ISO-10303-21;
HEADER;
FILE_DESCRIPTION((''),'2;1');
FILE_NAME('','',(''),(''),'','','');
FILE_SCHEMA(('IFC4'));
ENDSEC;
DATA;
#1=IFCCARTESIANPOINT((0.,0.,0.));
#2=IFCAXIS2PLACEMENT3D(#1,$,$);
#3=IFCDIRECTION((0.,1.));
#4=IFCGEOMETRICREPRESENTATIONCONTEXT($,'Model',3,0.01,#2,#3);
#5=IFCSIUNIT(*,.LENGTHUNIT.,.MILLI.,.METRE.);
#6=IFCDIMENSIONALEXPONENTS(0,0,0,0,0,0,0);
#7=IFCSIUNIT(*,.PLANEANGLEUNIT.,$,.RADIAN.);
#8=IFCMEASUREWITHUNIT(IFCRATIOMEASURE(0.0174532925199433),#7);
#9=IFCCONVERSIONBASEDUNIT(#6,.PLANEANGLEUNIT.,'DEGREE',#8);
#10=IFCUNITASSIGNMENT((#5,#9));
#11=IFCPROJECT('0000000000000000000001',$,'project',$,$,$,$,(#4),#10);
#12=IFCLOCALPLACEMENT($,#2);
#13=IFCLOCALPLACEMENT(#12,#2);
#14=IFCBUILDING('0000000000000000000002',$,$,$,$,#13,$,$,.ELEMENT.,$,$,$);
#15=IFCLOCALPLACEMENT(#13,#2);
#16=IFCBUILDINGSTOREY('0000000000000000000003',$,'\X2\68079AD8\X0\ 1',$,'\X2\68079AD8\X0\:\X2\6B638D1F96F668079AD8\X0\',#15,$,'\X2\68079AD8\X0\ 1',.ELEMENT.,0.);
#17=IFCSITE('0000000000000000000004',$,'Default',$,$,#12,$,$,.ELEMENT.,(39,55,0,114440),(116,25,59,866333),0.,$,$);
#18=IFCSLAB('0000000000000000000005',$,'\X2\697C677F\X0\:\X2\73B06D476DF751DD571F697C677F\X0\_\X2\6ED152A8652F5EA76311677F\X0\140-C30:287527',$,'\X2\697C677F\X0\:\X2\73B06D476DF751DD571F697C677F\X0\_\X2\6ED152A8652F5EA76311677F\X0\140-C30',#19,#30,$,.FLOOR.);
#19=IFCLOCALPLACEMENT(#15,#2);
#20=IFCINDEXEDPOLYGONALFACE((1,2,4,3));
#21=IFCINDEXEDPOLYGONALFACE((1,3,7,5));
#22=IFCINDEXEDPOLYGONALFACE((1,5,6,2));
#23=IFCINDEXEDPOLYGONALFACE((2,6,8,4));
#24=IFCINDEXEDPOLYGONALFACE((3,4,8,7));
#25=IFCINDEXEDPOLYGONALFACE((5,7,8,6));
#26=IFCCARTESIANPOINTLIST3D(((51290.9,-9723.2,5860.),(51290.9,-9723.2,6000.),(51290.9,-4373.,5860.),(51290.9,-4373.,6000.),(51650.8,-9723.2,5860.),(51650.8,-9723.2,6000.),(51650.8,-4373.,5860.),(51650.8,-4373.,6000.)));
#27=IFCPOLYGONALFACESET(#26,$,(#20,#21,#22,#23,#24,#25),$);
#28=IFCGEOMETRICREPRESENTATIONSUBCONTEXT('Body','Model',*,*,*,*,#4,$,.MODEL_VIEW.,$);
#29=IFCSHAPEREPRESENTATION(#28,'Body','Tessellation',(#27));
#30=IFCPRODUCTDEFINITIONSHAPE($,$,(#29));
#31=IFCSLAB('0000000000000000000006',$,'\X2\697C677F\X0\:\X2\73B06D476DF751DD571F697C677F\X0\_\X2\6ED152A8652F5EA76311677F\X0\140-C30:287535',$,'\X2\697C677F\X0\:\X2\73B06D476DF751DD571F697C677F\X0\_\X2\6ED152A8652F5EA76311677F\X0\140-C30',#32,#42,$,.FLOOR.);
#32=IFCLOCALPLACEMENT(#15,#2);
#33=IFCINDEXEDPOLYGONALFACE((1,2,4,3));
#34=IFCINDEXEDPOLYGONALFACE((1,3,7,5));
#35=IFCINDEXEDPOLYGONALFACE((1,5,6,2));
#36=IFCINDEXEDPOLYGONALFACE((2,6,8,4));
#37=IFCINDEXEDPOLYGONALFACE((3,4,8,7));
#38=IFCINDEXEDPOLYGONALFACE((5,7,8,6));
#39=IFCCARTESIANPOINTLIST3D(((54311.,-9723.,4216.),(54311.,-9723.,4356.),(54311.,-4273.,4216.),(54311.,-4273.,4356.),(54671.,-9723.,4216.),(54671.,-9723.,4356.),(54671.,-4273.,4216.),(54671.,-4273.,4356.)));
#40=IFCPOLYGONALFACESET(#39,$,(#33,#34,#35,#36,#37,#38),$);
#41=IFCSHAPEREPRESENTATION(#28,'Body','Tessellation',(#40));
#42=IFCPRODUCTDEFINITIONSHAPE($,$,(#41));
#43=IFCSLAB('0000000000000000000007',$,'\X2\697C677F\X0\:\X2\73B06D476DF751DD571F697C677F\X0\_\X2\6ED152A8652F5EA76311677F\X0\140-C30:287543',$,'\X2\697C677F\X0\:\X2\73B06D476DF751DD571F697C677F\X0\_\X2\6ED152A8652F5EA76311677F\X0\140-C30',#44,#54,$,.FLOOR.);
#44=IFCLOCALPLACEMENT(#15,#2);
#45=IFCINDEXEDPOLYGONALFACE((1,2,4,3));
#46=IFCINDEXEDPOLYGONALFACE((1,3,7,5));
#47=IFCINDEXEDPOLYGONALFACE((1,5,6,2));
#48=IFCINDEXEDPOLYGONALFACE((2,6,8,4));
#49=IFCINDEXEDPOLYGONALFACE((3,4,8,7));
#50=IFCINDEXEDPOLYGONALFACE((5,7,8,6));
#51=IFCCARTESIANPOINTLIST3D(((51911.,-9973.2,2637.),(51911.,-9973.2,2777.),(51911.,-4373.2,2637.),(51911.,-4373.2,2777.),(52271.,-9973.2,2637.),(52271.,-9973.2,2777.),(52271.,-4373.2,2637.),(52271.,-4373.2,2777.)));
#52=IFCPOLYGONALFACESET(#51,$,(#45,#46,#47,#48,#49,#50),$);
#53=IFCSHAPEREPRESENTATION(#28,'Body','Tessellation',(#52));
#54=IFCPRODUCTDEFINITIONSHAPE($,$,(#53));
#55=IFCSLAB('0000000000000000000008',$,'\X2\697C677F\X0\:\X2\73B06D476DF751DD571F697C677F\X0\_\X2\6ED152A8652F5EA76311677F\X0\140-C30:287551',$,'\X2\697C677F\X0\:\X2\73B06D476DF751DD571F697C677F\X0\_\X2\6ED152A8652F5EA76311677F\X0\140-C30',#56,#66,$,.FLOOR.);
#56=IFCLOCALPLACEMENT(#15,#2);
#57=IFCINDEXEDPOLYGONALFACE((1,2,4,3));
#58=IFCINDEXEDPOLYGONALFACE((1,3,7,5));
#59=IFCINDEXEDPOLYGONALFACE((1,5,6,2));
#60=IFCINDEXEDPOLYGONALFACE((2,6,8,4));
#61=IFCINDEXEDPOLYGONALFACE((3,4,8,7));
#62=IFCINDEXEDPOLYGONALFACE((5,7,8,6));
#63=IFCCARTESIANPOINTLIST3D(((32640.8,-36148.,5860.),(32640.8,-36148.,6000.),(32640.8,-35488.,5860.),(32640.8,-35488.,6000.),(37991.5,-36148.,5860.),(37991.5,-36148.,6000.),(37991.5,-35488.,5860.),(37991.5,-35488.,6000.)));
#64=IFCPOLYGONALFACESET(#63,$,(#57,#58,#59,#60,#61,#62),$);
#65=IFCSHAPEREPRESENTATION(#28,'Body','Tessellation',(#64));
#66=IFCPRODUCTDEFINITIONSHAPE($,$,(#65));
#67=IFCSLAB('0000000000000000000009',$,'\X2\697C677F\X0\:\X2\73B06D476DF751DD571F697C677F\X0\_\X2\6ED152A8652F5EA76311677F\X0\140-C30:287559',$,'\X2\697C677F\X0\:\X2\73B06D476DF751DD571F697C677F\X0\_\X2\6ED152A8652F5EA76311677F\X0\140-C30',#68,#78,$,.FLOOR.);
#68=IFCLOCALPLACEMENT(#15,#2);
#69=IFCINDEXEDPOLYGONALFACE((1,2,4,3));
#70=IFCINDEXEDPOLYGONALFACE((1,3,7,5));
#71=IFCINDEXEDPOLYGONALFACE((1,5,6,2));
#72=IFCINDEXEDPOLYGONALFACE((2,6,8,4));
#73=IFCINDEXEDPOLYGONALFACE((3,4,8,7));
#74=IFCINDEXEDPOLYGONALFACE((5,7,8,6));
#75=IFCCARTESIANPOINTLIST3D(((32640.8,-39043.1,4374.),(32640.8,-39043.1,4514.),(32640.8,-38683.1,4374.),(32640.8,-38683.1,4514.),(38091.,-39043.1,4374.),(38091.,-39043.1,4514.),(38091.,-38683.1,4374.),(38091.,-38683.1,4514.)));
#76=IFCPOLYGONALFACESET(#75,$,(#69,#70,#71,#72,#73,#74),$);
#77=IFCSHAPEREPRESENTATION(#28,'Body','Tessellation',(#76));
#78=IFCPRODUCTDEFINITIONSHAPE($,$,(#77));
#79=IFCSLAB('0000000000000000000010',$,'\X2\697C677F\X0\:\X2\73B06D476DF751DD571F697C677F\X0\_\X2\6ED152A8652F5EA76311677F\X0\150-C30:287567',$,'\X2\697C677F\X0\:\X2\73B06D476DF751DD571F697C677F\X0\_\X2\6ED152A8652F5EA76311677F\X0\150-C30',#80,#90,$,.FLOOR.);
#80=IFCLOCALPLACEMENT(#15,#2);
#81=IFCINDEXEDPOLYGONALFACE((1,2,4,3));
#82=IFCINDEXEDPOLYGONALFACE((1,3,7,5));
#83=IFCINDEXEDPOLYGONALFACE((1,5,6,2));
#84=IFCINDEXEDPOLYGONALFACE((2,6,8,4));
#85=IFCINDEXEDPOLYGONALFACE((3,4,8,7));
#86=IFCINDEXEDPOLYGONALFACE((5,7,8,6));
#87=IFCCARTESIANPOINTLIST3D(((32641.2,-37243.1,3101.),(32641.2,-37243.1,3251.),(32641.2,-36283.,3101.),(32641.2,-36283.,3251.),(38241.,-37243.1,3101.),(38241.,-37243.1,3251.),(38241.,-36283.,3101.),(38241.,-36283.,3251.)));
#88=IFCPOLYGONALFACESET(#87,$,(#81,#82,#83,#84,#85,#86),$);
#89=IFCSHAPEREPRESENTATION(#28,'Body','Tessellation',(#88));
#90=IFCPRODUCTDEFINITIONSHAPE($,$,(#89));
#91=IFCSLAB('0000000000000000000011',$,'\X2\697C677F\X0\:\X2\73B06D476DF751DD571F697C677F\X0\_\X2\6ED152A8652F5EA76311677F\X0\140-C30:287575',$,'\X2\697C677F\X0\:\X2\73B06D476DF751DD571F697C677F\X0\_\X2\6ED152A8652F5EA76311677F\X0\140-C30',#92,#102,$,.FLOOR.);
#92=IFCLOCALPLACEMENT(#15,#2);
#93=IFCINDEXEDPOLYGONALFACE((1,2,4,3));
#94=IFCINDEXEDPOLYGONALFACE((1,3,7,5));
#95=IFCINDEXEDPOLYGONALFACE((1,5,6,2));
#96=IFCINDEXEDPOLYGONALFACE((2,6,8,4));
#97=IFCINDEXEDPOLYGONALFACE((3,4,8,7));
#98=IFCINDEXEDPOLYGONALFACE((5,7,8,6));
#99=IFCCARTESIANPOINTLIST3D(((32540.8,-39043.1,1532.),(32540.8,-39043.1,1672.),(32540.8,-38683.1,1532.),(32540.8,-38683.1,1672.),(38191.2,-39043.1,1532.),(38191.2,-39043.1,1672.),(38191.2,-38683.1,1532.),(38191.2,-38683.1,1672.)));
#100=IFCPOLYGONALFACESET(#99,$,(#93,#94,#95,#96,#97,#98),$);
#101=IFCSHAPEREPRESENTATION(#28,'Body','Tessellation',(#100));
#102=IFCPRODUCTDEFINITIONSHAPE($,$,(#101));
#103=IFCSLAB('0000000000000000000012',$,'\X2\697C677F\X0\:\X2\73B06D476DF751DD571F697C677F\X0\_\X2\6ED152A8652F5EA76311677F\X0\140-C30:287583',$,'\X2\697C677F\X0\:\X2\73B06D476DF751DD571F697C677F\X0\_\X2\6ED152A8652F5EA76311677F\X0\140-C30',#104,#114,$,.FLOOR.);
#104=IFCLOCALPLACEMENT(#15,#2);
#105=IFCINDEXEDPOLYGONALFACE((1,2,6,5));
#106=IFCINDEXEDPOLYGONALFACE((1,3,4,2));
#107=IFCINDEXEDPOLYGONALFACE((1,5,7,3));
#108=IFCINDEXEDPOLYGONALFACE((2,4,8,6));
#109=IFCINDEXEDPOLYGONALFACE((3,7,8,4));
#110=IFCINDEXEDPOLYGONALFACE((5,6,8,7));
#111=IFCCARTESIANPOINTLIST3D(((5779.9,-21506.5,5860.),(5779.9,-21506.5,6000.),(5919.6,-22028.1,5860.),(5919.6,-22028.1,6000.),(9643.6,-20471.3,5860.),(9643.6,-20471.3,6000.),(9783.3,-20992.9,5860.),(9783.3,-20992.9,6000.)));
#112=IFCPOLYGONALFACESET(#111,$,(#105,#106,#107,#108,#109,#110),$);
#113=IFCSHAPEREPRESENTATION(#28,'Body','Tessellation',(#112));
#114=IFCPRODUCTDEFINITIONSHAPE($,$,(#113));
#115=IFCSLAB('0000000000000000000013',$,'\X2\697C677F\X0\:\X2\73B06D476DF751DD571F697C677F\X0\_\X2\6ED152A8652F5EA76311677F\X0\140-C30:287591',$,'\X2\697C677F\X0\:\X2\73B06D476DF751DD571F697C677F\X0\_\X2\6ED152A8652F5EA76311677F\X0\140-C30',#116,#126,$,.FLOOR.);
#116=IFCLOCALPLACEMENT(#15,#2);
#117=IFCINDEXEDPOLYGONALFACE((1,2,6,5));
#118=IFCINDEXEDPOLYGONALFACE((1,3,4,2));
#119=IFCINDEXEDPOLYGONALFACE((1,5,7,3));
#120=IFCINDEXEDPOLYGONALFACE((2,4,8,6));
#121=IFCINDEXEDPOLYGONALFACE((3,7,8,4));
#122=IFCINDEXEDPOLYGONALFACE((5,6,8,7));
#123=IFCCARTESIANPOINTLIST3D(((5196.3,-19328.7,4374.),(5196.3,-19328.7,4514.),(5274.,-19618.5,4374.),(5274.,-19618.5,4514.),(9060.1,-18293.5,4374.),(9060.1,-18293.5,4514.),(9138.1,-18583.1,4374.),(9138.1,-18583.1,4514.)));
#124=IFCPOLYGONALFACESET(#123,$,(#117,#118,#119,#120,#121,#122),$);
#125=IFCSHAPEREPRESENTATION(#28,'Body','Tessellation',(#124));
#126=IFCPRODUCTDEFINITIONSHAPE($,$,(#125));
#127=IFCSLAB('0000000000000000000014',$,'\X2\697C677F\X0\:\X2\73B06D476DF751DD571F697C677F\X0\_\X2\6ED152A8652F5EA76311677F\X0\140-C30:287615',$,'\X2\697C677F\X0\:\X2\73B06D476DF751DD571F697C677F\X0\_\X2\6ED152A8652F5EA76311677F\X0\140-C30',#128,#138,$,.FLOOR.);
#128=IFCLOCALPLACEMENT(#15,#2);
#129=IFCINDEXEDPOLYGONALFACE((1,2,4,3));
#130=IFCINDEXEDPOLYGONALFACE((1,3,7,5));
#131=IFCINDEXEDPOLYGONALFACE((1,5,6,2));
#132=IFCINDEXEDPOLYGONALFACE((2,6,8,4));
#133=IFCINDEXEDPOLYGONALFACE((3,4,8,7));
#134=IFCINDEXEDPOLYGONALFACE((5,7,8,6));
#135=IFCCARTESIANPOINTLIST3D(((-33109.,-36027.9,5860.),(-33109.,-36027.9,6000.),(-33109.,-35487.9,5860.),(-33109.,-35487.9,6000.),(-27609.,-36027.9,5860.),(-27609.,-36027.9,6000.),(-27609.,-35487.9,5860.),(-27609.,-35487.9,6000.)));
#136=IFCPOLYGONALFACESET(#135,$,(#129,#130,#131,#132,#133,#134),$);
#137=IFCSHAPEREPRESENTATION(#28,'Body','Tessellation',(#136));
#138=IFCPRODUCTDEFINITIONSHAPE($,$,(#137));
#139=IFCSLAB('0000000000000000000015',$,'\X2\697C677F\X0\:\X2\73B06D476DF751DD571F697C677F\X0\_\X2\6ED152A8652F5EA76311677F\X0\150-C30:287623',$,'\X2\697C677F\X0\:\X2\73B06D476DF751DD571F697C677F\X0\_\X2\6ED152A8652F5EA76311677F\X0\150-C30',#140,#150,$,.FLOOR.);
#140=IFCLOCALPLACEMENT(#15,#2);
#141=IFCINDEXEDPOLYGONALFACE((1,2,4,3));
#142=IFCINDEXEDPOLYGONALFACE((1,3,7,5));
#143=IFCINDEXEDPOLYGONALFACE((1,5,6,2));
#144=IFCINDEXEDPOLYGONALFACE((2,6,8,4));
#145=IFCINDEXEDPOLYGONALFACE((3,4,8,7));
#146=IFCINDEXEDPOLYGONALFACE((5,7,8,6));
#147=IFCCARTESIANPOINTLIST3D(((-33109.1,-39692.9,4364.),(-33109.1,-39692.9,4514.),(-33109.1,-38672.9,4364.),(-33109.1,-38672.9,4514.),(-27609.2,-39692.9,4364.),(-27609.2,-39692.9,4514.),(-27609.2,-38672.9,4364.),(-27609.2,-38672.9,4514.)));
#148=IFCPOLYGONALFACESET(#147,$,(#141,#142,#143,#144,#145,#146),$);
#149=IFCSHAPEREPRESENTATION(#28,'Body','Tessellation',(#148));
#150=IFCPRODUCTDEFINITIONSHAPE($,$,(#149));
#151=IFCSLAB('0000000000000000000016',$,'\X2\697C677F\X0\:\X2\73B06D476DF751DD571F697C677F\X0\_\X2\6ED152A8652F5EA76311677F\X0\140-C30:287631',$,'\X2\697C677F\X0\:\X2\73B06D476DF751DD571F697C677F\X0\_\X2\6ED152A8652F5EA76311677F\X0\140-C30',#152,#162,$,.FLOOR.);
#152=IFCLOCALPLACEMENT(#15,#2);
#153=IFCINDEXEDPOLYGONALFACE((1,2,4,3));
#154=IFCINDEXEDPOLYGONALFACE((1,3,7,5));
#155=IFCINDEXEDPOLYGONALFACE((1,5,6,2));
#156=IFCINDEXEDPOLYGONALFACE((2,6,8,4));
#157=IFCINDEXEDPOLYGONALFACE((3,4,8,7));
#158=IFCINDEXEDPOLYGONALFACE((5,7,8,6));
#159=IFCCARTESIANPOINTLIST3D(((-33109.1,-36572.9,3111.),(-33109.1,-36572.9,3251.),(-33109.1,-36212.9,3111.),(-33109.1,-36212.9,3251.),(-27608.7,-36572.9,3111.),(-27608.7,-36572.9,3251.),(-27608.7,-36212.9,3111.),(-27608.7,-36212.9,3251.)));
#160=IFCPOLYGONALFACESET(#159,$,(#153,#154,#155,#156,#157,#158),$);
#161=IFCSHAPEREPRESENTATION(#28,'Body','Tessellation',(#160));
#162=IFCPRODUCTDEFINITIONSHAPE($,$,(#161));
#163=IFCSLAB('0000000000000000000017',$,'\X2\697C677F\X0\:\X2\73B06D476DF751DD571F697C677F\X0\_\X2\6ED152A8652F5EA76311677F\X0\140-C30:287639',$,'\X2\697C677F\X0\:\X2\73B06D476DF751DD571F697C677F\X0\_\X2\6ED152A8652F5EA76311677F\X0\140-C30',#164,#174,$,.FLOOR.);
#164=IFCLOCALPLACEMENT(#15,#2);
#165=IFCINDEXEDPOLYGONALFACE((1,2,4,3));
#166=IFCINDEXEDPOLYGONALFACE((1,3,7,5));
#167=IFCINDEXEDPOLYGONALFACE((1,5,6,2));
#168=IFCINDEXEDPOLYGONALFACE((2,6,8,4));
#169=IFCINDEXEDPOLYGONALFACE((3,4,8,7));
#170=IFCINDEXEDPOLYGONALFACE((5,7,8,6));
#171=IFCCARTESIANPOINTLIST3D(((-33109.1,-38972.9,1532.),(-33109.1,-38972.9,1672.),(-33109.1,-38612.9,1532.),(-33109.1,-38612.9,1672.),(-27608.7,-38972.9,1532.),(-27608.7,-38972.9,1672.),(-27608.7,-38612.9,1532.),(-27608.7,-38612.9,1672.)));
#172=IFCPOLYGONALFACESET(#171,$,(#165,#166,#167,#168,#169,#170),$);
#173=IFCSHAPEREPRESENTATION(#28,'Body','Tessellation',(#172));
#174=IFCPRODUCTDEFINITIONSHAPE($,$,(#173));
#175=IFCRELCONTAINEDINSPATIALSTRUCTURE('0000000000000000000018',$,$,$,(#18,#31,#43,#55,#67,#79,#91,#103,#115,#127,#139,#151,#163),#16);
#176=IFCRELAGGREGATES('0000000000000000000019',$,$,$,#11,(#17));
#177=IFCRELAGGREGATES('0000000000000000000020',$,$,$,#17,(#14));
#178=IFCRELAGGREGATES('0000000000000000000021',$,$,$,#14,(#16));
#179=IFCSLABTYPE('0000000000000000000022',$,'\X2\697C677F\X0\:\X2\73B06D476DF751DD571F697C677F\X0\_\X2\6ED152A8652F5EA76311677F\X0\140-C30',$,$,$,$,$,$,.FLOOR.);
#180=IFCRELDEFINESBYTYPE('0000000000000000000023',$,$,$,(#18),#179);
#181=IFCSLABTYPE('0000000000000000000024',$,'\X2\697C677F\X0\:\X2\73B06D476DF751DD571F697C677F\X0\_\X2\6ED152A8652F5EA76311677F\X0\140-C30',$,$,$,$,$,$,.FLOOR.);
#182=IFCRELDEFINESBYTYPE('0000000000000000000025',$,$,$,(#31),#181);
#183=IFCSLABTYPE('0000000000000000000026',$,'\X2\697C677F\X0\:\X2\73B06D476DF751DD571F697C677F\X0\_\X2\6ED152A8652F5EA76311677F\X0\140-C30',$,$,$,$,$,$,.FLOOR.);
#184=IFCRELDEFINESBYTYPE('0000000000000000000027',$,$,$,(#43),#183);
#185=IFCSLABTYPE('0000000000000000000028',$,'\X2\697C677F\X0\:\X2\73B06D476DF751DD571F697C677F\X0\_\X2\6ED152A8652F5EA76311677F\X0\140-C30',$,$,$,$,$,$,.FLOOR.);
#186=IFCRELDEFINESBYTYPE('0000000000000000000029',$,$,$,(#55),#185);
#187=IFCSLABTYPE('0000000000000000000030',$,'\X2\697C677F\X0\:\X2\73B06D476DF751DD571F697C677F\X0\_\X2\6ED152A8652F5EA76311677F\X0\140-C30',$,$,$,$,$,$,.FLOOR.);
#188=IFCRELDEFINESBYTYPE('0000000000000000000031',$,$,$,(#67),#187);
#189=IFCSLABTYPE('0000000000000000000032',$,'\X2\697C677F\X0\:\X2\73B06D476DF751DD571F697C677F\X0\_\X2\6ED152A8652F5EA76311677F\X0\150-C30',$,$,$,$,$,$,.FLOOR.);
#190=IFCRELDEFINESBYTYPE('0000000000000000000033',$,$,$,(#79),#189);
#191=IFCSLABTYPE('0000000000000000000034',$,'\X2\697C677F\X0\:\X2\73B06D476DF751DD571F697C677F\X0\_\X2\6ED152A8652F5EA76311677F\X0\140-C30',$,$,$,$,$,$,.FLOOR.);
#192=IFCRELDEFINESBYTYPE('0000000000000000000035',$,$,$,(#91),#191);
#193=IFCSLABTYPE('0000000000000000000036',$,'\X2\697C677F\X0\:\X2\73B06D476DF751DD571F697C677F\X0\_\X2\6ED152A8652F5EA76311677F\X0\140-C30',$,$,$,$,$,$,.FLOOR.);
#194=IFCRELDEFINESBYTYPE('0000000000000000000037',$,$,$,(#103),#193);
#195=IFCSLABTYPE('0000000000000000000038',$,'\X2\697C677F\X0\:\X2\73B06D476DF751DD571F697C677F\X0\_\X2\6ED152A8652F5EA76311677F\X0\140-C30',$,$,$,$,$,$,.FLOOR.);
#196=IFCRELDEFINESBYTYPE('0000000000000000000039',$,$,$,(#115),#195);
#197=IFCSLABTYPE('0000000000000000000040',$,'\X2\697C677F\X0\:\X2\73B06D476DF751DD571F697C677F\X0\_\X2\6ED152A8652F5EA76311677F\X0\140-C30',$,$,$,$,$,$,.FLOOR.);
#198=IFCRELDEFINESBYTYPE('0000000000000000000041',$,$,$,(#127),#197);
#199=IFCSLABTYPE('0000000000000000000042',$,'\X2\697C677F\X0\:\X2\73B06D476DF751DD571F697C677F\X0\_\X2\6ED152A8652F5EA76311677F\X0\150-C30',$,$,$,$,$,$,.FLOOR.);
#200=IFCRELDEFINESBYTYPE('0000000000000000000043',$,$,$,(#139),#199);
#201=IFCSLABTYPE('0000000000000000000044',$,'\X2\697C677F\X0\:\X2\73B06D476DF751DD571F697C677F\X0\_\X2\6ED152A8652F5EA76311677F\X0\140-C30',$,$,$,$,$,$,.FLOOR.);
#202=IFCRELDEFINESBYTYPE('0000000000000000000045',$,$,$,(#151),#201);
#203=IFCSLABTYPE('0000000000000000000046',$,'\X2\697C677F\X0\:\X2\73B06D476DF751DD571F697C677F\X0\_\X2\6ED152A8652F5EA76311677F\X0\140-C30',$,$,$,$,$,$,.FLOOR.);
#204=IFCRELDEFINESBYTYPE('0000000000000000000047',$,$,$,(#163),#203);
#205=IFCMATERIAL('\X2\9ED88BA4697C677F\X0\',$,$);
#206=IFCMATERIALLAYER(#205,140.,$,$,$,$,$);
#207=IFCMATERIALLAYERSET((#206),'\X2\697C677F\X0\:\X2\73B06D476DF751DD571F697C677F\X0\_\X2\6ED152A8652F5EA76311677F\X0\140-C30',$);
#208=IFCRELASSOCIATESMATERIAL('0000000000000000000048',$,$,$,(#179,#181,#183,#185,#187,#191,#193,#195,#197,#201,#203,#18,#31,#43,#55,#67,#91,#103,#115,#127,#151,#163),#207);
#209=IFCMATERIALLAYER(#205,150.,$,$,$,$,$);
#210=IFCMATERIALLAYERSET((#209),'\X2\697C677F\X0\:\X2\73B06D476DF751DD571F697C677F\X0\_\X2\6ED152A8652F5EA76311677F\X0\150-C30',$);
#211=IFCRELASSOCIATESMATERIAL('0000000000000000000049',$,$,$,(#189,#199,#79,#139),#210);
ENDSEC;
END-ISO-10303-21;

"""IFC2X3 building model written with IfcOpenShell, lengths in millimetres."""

from ifc_helpers import new_model, entity, si_unit, converted_unit, direction, frame, frame_2d, origin, origin_2d_with_axis, place, context, subcontext, project, spatial, polyline, rectangle, outline, extrude, material, layer, layer_set, layer_usage, type_object, element, save


model = new_model("IFC2X3")

# Units and contexts
model_context = context("Model", 3, precision=0.01, world=origin(), true_north=direction((0.0, 1.0)))
body_context = subcontext(model_context, "Body", "Model", "MODEL_VIEW")
ifc_project = project(units=[si_unit("LENGTHUNIT", "METRE", prefix="MILLI"), converted_unit("PLANEANGLEUNIT", "DEGREE", entity("IfcRatioMeasure", 0.0174532925199433), si_unit("PLANEANGLEUNIT", "RADIAN"), dimensions=[0, 0, 0, 0, 0, 0, 0])], contexts=[model_context])

# Site, building, storey
site_placement = place(None, origin())
site = spatial("IfcSite", under=ifc_project, at=site_placement, Name="Default", CompositionType="ELEMENT", RefLatitude=(39, 55, 0, 114440), RefLongitude=(116, 25, 59, 866333), RefElevation=0.0)
building_placement = place(site_placement, origin())
building = spatial("IfcBuilding", under=site, at=building_placement, CompositionType="ELEMENT")
storey_placement = place(building_placement, origin())
storey = spatial("IfcBuildingStorey", under=building, at=storey_placement, Name="标高 1", ObjectType="标高:正负零标高", LongName="标高 1", CompositionType="ELEMENT", Elevation=0.0)

# Slabs
ifc_material = material(Name="默认楼板")
ifc_layer_1 = layer(ifc_material, 140.0)
ifc_layer_set_1 = layer_set([ifc_layer_1], Name="楼板:现浇混凝土楼板_滑动支座挑板140-C30")
ifc_layer_2 = layer(ifc_material, 150.0)
ifc_layer_set_2 = layer_set([ifc_layer_2], Name="楼板:现浇混凝土楼板_滑动支座挑板150-C30")
ifc_layer_usage_1 = layer_usage(ifc_layer_set_1, "AXIS3", "POSITIVE", 0.0)
slab_type_1 = type_object("IfcSlabType", Name="楼板:现浇混凝土楼板_滑动支座挑板140-C30", PredefinedType="FLOOR", material=ifc_layer_set_1)
slab_1_placement = place(building_placement, origin())
element("IfcSlab", 1, at=slab_1_placement, inside=storey, type_object=slab_type_1, material=ifc_layer_usage_1, Name="楼板:现浇混凝土楼板_滑动支座挑板140-C30:287527", ObjectType="楼板:现浇混凝土楼板_滑动支座挑板140-C30", PredefinedType="FLOOR", context=body_context, shape_type="SweptSolid", body=[
    extrude(rectangle(XDim=5350.2, YDim=360.0, at=frame_2d((0.0, 0.0), x_axis=(1.0, 0.0))), frame((51470.8, -7048.1, 6000.0), z_axis=(0.0, 0.0, -1.0), x_axis=(0.0, 1.0, 0.0)), (0.0, 0.0, 1.0), 140.0),
])
ifc_layer_usage_2 = layer_usage(ifc_layer_set_1, "AXIS3", "POSITIVE", 0.0)
slab_type_2 = type_object("IfcSlabType", Name="楼板:现浇混凝土楼板_滑动支座挑板140-C30", PredefinedType="FLOOR", material=ifc_layer_set_1)
slab_2_placement = place(building_placement, origin())
element("IfcSlab", 2, at=slab_2_placement, inside=storey, type_object=slab_type_2, material=ifc_layer_usage_2, Name="楼板:现浇混凝土楼板_滑动支座挑板140-C30:287535", ObjectType="楼板:现浇混凝土楼板_滑动支座挑板140-C30", PredefinedType="FLOOR", context=body_context, shape_type="SweptSolid", body=[
    extrude(rectangle(XDim=5450.0, YDim=360.0, at=origin_2d_with_axis()), frame((54491.0, -6998.0, 4356.0), z_axis=(0.0, 0.0, -1.0), x_axis=(0.0, 1.0, 0.0)), (0.0, 0.0, 1.0), 140.0),
])
ifc_layer_usage_3 = layer_usage(ifc_layer_set_1, "AXIS3", "POSITIVE", 0.0)
slab_type_3 = type_object("IfcSlabType", Name="楼板:现浇混凝土楼板_滑动支座挑板140-C30", PredefinedType="FLOOR", material=ifc_layer_set_1)
slab_3_placement = place(building_placement, origin())
element("IfcSlab", 3, at=slab_3_placement, inside=storey, type_object=slab_type_3, material=ifc_layer_usage_3, Name="楼板:现浇混凝土楼板_滑动支座挑板140-C30:287543", ObjectType="楼板:现浇混凝土楼板_滑动支座挑板140-C30", PredefinedType="FLOOR", context=body_context, shape_type="SweptSolid", body=[
    extrude(rectangle(XDim=5600.0, YDim=360.0, at=frame_2d((0.0, 0.0), x_axis=(1.0, 0.0))), frame((52091.0, -7173.2, 2777.0), z_axis=(0.0, 0.0, -1.0), x_axis=(0.0, 1.0, 0.0)), (0.0, 0.0, 1.0), 140.0),
])
ifc_layer_usage_4 = layer_usage(ifc_layer_set_1, "AXIS3", "POSITIVE", 0.0)
slab_type_4 = type_object("IfcSlabType", Name="楼板:现浇混凝土楼板_滑动支座挑板140-C30", PredefinedType="FLOOR", material=ifc_layer_set_1)
slab_4_placement = place(building_placement, origin())
element("IfcSlab", 4, at=slab_4_placement, inside=storey, type_object=slab_type_4, material=ifc_layer_usage_4, Name="楼板:现浇混凝土楼板_滑动支座挑板140-C30:287551", ObjectType="楼板:现浇混凝土楼板_滑动支座挑板140-C30", PredefinedType="FLOOR", context=body_context, shape_type="SweptSolid", body=[
    extrude(rectangle(XDim=660.0, YDim=5350.7, at=origin_2d_with_axis()), frame((35316.1, -35818.0, 6000.0), z_axis=(0.0, 0.0, -1.0), x_axis=(0.0, 1.0, 0.0)), (0.0, 0.0, 1.0), 140.0),
])
ifc_layer_usage_5 = layer_usage(ifc_layer_set_1, "AXIS3", "POSITIVE", 0.0)
slab_type_5 = type_object("IfcSlabType", Name="楼板:现浇混凝土楼板_滑动支座挑板140-C30", PredefinedType="FLOOR", material=ifc_layer_set_1)
slab_5_placement = place(building_placement, origin())
element("IfcSlab", 5, at=slab_5_placement, inside=storey, type_object=slab_type_5, material=ifc_layer_usage_5, Name="楼板:现浇混凝土楼板_滑动支座挑板140-C30:287559", ObjectType="楼板:现浇混凝土楼板_滑动支座挑板140-C30", PredefinedType="FLOOR", context=body_context, shape_type="SweptSolid", body=[
    extrude(rectangle(XDim=360.0, YDim=5450.2, at=frame_2d((0.0, 0.0), x_axis=(1.0, 0.0))), frame((35365.9, -38863.1, 4514.0), z_axis=(0.0, 0.0, -1.0), x_axis=(0.0, 1.0, 0.0)), (0.0, 0.0, 1.0), 140.0),
])
ifc_layer_usage_6 = layer_usage(ifc_layer_set_2, "AXIS3", "POSITIVE", 0.0)
slab_type_6 = type_object("IfcSlabType", Name="楼板:现浇混凝土楼板_滑动支座挑板150-C30", PredefinedType="FLOOR", material=ifc_layer_set_2)
slab_6_placement = place(building_placement, origin())
element("IfcSlab", 6, at=slab_6_placement, inside=storey, type_object=slab_type_6, material=ifc_layer_usage_6, Name="楼板:现浇混凝土楼板_滑动支座挑板150-C30:287567", ObjectType="楼板:现浇混凝土楼板_滑动支座挑板150-C30", PredefinedType="FLOOR", context=body_context, shape_type="SweptSolid", body=[
    extrude(rectangle(XDim=960.2, YDim=5599.8, at=frame_2d((0.0, 0.0), x_axis=(1.0, 0.0))), frame((35441.1, -36763.1, 3251.0), z_axis=(0.0, 0.0, -1.0), x_axis=(0.0, 1.0, 0.0)), (0.0, 0.0, 1.0), 150.0),
])
ifc_layer_usage_7 = layer_usage(ifc_layer_set_1, "AXIS3", "POSITIVE", 0.0)
slab_type_7 = type_object("IfcSlabType", Name="楼板:现浇混凝土楼板_滑动支座挑板140-C30", PredefinedType="FLOOR", material=ifc_layer_set_1)
slab_7_placement = place(building_placement, origin())
element("IfcSlab", 7, at=slab_7_placement, inside=storey, type_object=slab_type_7, material=ifc_layer_usage_7, Name="楼板:现浇混凝土楼板_滑动支座挑板140-C30:287575", ObjectType="楼板:现浇混凝土楼板_滑动支座挑板140-C30", PredefinedType="FLOOR", context=body_context, shape_type="SweptSolid", body=[
    extrude(rectangle(XDim=360.0, YDim=5650.4, at=frame_2d((0.0, 0.0), x_axis=(1.0, 0.0))), frame((35366.0, -38863.1, 1672.0), z_axis=(0.0, 0.0, -1.0), x_axis=(0.0, 1.0, 0.0)), (0.0, 0.0, 1.0), 140.0),
])
ifc_layer_usage_8 = layer_usage(ifc_layer_set_1, "AXIS3", "POSITIVE", 0.0)
slab_type_8 = type_object("IfcSlabType", Name="楼板:现浇混凝土楼板_滑动支座挑板140-C30", PredefinedType="FLOOR", material=ifc_layer_set_1)
slab_8_placement = place(building_placement, origin())
element("IfcSlab", 8, at=slab_8_placement, inside=storey, type_object=slab_type_8, material=ifc_layer_usage_8, Name="楼板:现浇混凝土楼板_滑动支座挑板140-C30:287583", ObjectType="楼板:现浇混凝土楼板_滑动支座挑板140-C30", PredefinedType="FLOOR", context=body_context, shape_type="SweptSolid", body=[
    extrude(outline(polyline([(-2000.0, -270.0), (2000.0, -270.0), (2000.0, 270.0), (-2000.0, 270.0), (-2000.0, -270.0)])), frame((7781.6, -21249.7, 6000.0), z_axis=(0.0, 0.0, -1.0), x_axis=(0.965926, 0.258819, 0.0)), (0.0, 0.0, 1.0), 140.0),
])
ifc_layer_usage_9 = layer_usage(ifc_layer_set_1, "AXIS3", "POSITIVE", 0.0)
slab_type_9 = type_object("IfcSlabType", Name="楼板:现浇混凝土楼板_滑动支座挑板140-C30", PredefinedType="FLOOR", material=ifc_layer_set_1)
slab_9_placement = place(building_placement, origin())
element("IfcSlab", 9, at=slab_9_placement, inside=storey, type_object=slab_type_9, material=ifc_layer_usage_9, Name="楼板:现浇混凝土楼板_滑动支座挑板140-C30:287591", ObjectType="楼板:现浇混凝土楼板_滑动支座挑板140-C30", PredefinedType="FLOOR", context=body_context, shape_type="SweptSolid", body=[
    extrude(outline(polyline([(-2000.1, -150.0), (1999.9, -150.0), (2000.3, 149.9), (-2000.1, 150.0), (-2000.1, -150.0)])), frame((7167.1, -18956.0, 4514.0), z_axis=(0.0, 0.0, -1.0), x_axis=(0.965932, 0.258797, 0.0)), (0.0, 0.0, 1.0), 140.0),
])
ifc_layer_usage_10 = layer_usage(ifc_layer_set_1, "AXIS3", "POSITIVE", 0.0)
slab_type_10 = type_object("IfcSlabType", Name="楼板:现浇混凝土楼板_滑动支座挑板140-C30", PredefinedType="FLOOR", material=ifc_layer_set_1)
slab_10_placement = place(building_placement, origin())
element("IfcSlab", 10, at=slab_10_placement, inside=storey, type_object=slab_type_10, material=ifc_layer_usage_10, Name="楼板:现浇混凝土楼板_滑动支座挑板140-C30:287615", ObjectType="楼板:现浇混凝土楼板_滑动支座挑板140-C30", PredefinedType="FLOOR", context=body_context, shape_type="SweptSolid", body=[
    extrude(rectangle(XDim=540.0, YDim=5500.0, at=frame_2d((0.0, 0.0), x_axis=(1.0, 0.0))), frame((-30359.0, -35757.9, 6000.0), z_axis=(0.0, 0.0, -1.0), x_axis=(0.0, 1.0, 0.0)), (0.0, 0.0, 1.0), 140.0),
])
ifc_layer_usage_11 = layer_usage(ifc_layer_set_2, "AXIS3", "POSITIVE", 0.0)
slab_type_11 = type_object("IfcSlabType", Name="楼板:现浇混凝土楼板_滑动支座挑板150-C30", PredefinedType="FLOOR", material=ifc_layer_set_2)
slab_11_placement = place(building_placement, origin())
element("IfcSlab", 11, at=slab_11_placement, inside=storey, type_object=slab_type_11, material=ifc_layer_usage_11, Name="楼板:现浇混凝土楼板_滑动支座挑板150-C30:287623", ObjectType="楼板:现浇混凝土楼板_滑动支座挑板150-C30", PredefinedType="FLOOR", context=body_context, shape_type="SweptSolid", body=[
    extrude(rectangle(XDim=1020.0, YDim=5500.0, at=frame_2d((0.0, 0.0), x_axis=(1.0, 0.0))), frame((-30359.2, -39182.9, 4514.0), z_axis=(0.0, 0.0, -1.0), x_axis=(0.0, 1.0, 0.0)), (0.0, 0.0, 1.0), 150.0),
])
ifc_layer_usage_12 = layer_usage(ifc_layer_set_1, "AXIS3", "POSITIVE", 0.0)
slab_type_12 = type_object("IfcSlabType", Name="楼板:现浇混凝土楼板_滑动支座挑板140-C30", PredefinedType="FLOOR", material=ifc_layer_set_1)
slab_12_placement = place(building_placement, origin())
element("IfcSlab", 12, at=slab_12_placement, inside=storey, type_object=slab_type_12, material=ifc_layer_usage_12, Name="楼板:现浇混凝土楼板_滑动支座挑板140-C30:287631", ObjectType="楼板:现浇混凝土楼板_滑动支座挑板140-C30", PredefinedType="FLOOR", context=body_context, shape_type="SweptSolid", body=[
    extrude(rectangle(XDim=360.0, YDim=5500.4, at=frame_2d((0.0, 0.0), x_axis=(1.0, 0.0))), frame((-30358.9, -36392.9, 3251.0), z_axis=(0.0, 0.0, -1.0), x_axis=(0.0, 1.0, 0.0)), (0.0, 0.0, 1.0), 140.0),
])
ifc_layer_usage_13 = layer_usage(ifc_layer_set_1, "AXIS3", "POSITIVE", 0.0)
slab_type_13 = type_object("IfcSlabType", Name="楼板:现浇混凝土楼板_滑动支座挑板140-C30", PredefinedType="FLOOR", material=ifc_layer_set_1)
slab_13_placement = place(building_placement, origin())
element("IfcSlab", 13, at=slab_13_placement, inside=storey, type_object=slab_type_13, material=ifc_layer_usage_13, Name="楼板:现浇混凝土楼板_滑动支座挑板140-C30:287639", ObjectType="楼板:现浇混凝土楼板_滑动支座挑板140-C30", PredefinedType="FLOOR", context=body_context, shape_type="SweptSolid", body=[
    extrude(rectangle(XDim=360.0, YDim=5500.4, at=frame_2d((0.0, 0.0), x_axis=(1.0, 0.0))), frame((-30358.9, -38792.9, 1672.0), z_axis=(0.0, 0.0, -1.0), x_axis=(0.0, 1.0, 0.0)), (0.0, 0.0, 1.0), 140.0),
])

save(model, "model.ifc")
